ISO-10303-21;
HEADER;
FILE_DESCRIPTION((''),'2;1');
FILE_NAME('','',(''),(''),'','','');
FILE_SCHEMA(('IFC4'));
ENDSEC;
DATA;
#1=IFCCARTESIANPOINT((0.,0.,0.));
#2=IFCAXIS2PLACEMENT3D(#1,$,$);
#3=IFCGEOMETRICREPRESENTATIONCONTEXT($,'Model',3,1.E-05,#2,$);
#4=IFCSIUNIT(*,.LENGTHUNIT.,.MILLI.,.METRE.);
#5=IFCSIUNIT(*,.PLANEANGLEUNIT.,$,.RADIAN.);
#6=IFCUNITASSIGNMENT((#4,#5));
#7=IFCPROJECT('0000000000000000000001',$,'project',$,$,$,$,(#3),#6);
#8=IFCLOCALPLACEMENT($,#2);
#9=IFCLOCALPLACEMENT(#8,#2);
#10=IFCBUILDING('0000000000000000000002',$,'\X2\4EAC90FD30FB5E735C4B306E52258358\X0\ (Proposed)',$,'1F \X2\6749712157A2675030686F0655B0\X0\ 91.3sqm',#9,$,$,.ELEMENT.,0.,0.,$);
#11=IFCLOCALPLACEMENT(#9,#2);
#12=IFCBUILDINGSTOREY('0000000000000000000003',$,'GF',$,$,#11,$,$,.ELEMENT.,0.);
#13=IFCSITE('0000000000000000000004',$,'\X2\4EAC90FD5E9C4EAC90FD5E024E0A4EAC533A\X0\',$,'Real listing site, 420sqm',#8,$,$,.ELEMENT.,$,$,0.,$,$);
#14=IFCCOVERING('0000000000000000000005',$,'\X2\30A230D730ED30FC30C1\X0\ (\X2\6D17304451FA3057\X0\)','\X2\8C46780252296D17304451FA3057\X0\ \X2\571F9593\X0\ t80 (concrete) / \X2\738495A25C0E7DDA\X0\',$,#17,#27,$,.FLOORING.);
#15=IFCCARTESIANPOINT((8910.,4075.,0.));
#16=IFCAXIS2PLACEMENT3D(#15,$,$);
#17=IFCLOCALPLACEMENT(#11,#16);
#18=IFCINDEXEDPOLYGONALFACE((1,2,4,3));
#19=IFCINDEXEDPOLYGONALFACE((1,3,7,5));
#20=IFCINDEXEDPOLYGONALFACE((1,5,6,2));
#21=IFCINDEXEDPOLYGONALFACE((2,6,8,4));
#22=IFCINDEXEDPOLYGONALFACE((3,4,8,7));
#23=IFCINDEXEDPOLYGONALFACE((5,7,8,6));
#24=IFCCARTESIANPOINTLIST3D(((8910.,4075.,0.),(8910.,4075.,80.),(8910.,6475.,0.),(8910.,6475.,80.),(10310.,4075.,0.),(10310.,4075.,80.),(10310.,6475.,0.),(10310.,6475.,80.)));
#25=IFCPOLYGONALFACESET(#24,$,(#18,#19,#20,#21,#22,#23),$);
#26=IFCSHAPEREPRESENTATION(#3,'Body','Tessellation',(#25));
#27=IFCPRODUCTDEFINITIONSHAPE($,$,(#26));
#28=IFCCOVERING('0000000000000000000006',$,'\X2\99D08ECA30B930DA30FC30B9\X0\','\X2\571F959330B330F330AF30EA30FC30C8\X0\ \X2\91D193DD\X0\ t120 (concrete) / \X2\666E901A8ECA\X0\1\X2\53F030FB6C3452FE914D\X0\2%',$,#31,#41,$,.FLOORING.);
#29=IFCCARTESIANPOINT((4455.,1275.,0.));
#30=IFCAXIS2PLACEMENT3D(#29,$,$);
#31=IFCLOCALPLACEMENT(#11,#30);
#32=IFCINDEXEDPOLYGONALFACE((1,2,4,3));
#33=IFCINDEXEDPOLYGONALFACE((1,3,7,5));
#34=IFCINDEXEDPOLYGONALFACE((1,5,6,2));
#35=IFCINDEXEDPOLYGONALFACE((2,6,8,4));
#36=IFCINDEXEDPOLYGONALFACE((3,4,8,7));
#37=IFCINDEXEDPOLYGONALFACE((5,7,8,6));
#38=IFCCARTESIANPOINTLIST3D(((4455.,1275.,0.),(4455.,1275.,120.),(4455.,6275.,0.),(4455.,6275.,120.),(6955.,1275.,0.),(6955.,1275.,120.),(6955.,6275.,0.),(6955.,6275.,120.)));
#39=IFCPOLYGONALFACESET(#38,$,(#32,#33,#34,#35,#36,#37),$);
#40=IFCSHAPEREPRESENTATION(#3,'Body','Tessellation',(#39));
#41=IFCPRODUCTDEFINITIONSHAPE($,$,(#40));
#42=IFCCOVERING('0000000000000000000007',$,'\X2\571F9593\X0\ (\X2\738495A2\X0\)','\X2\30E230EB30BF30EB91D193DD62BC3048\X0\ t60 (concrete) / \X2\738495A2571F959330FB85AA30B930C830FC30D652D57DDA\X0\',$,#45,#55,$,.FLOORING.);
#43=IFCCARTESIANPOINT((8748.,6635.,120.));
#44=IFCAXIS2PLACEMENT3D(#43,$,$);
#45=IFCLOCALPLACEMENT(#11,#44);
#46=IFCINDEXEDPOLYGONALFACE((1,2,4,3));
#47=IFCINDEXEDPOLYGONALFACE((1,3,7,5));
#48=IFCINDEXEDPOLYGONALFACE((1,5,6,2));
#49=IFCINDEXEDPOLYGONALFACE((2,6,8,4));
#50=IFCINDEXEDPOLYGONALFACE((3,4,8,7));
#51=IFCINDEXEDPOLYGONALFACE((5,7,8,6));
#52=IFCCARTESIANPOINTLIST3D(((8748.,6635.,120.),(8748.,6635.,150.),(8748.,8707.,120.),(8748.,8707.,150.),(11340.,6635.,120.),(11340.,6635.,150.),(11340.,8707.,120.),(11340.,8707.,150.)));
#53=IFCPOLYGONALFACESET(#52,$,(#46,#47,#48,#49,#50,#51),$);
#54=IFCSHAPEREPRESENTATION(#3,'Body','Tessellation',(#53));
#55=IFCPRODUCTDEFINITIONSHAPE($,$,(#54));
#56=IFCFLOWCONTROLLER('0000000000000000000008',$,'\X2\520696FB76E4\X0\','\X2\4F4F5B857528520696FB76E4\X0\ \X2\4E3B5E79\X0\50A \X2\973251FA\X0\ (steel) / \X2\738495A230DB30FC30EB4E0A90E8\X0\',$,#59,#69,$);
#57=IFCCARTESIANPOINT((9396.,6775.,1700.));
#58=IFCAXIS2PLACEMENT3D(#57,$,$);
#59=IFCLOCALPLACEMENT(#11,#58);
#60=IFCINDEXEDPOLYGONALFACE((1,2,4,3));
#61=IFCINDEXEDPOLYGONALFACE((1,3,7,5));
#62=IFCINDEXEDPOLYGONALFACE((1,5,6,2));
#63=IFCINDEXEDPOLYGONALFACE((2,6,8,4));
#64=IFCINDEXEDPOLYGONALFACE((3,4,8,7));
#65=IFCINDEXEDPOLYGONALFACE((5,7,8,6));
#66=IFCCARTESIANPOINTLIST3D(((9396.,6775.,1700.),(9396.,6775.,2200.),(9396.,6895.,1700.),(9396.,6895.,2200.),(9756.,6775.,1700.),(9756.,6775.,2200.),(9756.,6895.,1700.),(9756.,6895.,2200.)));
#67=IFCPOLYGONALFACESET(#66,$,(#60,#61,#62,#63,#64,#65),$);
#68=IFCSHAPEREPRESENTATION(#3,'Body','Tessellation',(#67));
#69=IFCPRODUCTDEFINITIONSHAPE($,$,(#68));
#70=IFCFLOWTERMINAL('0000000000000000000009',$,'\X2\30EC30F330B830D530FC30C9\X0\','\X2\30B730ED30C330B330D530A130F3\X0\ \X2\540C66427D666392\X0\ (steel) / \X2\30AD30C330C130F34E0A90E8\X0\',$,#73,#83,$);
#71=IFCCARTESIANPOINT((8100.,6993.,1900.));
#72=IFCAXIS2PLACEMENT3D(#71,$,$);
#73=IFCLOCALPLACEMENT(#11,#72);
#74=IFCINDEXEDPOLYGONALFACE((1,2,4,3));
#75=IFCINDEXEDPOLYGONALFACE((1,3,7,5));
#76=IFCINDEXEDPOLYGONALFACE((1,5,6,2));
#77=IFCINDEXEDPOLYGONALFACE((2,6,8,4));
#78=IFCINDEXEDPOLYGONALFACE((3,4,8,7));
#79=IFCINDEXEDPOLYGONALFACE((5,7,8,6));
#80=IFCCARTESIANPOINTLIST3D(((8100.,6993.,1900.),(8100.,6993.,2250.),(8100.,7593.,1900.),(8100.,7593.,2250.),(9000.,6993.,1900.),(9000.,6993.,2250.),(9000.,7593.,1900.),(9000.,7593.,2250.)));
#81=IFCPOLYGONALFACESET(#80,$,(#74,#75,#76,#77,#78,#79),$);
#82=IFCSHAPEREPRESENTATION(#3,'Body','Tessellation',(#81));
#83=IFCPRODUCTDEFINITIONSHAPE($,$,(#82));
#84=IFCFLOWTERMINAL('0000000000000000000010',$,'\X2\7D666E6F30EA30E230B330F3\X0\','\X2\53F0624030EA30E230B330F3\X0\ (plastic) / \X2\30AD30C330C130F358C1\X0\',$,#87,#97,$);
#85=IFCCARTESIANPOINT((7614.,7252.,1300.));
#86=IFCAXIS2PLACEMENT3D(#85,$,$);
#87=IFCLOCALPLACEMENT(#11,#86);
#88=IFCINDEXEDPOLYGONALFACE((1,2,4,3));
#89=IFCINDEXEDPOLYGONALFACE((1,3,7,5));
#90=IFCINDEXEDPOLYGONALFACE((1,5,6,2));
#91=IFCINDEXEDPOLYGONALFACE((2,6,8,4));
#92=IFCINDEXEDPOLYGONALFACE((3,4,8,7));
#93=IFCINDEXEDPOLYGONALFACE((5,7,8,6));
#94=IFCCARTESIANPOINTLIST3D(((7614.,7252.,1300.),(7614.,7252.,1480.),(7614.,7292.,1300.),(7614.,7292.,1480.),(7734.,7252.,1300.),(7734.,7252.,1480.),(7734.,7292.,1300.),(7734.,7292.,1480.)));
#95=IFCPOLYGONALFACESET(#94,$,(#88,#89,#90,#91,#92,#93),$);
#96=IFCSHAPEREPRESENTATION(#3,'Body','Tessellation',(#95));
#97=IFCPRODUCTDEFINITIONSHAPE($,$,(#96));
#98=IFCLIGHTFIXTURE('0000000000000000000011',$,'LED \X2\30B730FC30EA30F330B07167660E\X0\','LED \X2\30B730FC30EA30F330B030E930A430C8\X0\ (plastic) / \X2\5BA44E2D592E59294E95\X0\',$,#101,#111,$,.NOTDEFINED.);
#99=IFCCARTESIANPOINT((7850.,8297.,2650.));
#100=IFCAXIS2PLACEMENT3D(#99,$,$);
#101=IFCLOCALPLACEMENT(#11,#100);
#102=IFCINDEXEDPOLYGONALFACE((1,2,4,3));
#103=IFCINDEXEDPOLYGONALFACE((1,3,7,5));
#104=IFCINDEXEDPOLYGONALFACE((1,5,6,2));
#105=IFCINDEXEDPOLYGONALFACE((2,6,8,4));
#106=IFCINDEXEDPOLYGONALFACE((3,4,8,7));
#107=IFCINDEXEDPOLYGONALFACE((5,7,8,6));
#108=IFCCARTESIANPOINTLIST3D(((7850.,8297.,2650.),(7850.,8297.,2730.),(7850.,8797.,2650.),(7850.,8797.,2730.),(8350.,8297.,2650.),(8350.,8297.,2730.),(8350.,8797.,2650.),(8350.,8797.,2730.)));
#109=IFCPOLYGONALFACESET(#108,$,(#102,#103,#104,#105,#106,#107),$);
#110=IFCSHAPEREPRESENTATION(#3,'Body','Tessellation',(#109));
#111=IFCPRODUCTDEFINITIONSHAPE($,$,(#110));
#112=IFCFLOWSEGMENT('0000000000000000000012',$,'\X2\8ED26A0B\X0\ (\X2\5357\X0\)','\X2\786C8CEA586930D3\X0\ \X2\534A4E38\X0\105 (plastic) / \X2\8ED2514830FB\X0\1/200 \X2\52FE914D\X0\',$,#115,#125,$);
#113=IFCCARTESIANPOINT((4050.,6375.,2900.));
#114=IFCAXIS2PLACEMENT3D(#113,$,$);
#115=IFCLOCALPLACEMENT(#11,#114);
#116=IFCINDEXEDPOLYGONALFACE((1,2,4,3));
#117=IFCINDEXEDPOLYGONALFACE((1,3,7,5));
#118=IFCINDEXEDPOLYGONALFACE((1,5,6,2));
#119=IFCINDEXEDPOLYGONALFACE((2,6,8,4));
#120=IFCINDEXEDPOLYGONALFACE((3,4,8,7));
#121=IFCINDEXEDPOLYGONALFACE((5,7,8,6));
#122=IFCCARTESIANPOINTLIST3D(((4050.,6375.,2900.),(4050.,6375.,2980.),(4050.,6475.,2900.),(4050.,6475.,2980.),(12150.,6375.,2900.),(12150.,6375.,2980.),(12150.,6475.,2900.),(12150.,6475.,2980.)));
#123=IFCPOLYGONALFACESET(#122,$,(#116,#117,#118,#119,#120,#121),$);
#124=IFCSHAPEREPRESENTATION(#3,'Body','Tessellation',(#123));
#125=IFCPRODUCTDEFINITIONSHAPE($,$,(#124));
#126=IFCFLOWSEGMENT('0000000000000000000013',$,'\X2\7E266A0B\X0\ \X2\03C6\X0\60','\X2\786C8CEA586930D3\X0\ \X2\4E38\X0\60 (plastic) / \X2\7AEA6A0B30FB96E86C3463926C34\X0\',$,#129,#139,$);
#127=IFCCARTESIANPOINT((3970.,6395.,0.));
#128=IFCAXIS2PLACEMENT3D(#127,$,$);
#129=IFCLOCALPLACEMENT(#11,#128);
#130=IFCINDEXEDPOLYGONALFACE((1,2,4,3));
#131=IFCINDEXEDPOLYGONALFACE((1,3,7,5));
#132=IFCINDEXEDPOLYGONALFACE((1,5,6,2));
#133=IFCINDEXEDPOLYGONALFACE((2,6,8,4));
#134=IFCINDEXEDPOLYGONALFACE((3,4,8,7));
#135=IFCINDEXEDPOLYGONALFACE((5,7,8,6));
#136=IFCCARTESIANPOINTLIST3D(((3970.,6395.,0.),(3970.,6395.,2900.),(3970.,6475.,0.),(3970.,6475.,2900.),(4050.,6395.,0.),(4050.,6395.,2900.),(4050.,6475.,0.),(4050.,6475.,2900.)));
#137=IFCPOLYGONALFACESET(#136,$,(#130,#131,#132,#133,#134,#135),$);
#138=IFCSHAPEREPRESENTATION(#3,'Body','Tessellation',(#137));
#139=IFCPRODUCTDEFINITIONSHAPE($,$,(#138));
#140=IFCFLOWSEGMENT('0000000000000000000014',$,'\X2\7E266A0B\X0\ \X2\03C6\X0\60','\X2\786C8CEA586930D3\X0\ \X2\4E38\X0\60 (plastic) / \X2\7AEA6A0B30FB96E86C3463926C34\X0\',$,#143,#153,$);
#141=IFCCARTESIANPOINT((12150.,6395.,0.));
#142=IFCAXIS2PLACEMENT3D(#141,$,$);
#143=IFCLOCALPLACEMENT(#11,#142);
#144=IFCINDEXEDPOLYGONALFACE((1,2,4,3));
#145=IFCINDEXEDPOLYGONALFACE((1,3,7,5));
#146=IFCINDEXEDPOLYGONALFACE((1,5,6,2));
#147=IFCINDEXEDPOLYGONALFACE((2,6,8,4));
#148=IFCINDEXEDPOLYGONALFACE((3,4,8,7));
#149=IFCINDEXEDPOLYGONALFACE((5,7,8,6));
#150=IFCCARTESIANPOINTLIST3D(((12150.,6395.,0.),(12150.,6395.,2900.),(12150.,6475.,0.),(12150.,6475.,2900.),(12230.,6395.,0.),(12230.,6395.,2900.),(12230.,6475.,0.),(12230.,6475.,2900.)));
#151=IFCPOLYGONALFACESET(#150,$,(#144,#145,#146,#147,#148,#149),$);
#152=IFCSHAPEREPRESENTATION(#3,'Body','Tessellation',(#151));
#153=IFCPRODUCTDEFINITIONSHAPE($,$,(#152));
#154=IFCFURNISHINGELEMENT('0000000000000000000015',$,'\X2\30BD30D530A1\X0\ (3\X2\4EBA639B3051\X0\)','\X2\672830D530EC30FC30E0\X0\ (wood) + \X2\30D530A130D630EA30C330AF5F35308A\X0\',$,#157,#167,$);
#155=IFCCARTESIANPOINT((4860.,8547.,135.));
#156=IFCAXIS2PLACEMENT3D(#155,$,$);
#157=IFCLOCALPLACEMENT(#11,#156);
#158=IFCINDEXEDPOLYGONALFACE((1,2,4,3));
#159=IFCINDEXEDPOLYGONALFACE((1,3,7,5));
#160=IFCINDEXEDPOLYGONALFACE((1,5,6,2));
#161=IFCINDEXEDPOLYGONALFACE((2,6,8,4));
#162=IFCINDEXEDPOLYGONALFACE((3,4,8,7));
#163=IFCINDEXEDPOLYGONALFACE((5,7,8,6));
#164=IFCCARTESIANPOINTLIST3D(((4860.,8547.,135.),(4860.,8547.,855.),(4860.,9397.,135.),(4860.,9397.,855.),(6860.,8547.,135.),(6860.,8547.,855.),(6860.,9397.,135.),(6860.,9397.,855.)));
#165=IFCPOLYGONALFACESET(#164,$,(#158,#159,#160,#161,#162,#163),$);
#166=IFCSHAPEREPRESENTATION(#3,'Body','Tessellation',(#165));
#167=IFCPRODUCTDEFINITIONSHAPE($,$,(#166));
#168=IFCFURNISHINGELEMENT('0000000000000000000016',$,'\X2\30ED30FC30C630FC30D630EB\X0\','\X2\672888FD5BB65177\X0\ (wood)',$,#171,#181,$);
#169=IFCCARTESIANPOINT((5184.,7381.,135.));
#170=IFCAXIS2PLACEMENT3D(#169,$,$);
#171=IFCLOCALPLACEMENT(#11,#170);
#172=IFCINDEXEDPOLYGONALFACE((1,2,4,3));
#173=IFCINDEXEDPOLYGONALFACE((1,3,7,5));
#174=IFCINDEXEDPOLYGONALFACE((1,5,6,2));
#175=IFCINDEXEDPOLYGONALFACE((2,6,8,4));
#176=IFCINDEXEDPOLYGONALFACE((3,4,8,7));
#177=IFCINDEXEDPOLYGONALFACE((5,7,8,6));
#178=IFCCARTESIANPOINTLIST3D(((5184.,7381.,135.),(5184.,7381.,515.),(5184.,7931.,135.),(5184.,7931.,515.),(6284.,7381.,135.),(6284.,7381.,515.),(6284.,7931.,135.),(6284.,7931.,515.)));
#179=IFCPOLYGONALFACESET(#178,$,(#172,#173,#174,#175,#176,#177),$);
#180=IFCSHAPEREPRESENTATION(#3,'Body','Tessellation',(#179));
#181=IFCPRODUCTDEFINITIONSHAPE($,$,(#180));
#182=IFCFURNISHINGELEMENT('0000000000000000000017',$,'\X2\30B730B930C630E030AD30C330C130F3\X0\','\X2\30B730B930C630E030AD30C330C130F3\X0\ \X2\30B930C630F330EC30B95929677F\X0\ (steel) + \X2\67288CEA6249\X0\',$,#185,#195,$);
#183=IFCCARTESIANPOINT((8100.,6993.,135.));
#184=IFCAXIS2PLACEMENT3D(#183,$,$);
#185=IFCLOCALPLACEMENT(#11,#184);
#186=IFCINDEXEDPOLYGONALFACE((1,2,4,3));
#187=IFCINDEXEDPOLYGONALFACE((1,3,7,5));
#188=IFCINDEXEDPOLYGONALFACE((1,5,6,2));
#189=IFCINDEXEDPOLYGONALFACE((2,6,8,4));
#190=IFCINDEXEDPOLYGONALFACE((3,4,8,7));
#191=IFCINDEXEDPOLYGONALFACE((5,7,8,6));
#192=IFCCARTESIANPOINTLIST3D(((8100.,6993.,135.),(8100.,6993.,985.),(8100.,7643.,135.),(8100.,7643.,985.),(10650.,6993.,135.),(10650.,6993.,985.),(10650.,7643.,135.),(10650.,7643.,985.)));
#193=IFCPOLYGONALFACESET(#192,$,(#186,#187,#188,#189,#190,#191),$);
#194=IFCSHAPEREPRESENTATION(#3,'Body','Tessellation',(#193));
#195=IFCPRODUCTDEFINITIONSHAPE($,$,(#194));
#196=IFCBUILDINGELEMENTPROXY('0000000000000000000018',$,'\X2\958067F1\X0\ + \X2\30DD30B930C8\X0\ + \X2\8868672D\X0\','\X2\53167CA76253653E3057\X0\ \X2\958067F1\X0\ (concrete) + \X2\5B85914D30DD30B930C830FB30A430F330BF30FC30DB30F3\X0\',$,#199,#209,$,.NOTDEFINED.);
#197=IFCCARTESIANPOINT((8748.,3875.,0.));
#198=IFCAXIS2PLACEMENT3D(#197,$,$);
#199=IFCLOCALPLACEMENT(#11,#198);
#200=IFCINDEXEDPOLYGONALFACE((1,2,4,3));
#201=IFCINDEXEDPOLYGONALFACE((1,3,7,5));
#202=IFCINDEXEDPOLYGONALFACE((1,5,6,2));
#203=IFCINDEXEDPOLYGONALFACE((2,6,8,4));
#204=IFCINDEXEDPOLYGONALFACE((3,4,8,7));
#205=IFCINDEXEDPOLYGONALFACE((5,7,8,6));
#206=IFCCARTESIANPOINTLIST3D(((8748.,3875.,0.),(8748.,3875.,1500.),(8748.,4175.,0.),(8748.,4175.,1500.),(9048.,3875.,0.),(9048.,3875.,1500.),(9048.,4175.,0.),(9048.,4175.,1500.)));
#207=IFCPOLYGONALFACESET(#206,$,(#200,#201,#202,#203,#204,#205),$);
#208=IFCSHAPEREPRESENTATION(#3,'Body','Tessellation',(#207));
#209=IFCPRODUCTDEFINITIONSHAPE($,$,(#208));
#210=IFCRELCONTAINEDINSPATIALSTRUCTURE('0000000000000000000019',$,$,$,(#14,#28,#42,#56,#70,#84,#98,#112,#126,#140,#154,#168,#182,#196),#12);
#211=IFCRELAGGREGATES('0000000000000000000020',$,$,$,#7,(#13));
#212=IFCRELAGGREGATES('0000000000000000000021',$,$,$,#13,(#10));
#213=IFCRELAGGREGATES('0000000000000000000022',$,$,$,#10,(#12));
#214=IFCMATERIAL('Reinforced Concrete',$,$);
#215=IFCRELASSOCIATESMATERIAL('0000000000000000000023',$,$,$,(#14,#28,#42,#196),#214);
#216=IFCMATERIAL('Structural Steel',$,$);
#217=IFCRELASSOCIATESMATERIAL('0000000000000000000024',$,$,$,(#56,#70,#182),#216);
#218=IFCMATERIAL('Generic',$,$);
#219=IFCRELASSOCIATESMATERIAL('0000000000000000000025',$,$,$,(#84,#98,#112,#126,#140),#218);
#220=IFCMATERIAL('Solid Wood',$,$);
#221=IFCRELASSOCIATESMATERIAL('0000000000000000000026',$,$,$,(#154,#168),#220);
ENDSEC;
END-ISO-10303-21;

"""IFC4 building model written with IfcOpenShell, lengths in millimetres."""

from ifc_helpers import new_model, si_unit, frame, frame_2d, origin, place, context, project, spatial, rectangle, extrude, material, element, save


model = new_model("IFC4")

# Units and contexts
model_context = context("Model", 3, precision=1e-05, world=origin())
ifc_project = project(units=[si_unit("LENGTHUNIT", "METRE", prefix="MILLI"), si_unit("PLANEANGLEUNIT", "RADIAN")], contexts=[model_context])

# Site, building, storey
site_placement = place(None, origin())
site = spatial("IfcSite", under=ifc_project, at=site_placement, Name="京都府京都市上京区", ObjectType="Real listing site, 420sqm", CompositionType="ELEMENT", RefElevation=0.0)
building_placement = place(site_placement, origin())
building = spatial("IfcBuilding", under=site, at=building_placement, Name="京都・平屋の別荘 (Proposed)", ObjectType="1F 杉無垢材と漆喰 91.3sqm", CompositionType="ELEMENT", ElevationOfRefHeight=0.0, ElevationOfTerrain=0.0)
storey_placement = place(building_placement, origin())
storey = spatial("IfcBuildingStorey", under=building, at=storey_placement, Name="GF", CompositionType="ELEMENT", Elevation=0.0)

# Shared definitions
ifc_material_1 = material(Name="Solid Wood")

# Shared definitions
ifc_material_2 = material(Name="Reinforced Concrete")

# Shared definitions
ifc_material_3 = material(Name="Structural Steel")

# Coverings
ifc_material_4 = material(Name="Generic")
covering_1_placement = place(storey_placement, frame((8910.0, 4075.0, 0.0)))
element("IfcCovering", 1, at=covering_1_placement, inside=storey, material=ifc_material_2, Name="アプローチ (洗い出し)", Description="豆砂利洗い出し 土間 t80 (concrete) / 玄関導線", PredefinedType="FLOORING", context=model_context, shape_type="SweptSolid", body=[
    extrude(rectangle(XDim=1400.0, YDim=2400.0, at=frame_2d((700.0, 1200.0))), frame((8910.0, 4075.0, 0.0)), (0.0, 0.0, 1.0), 80.0),
])
covering_2_placement = place(storey_placement, frame((4455.0, 1275.0, 0.0)))
element("IfcCovering", 2, at=covering_2_placement, inside=storey, material=ifc_material_2, Name="駐車スペース", Description="土間コンクリート 金鏝 t120 (concrete) / 普通車1台・水勾配2%", PredefinedType="FLOORING", context=model_context, shape_type="SweptSolid", body=[
    extrude(rectangle(XDim=2500.0, YDim=5000.0, at=frame_2d((1250.0, 2500.0))), frame((4455.0, 1275.0, 0.0)), (0.0, 0.0, 1.0), 120.0),
])
covering_3_placement = place(storey_placement, frame((8748.0, 6635.0, 120.0)))
element("IfcCovering", 3, at=covering_3_placement, inside=storey, material=ifc_material_2, Name="土間 (玄関)", Description="モルタル金鏝押え t60 (concrete) / 玄関土間・薪ストーブ動線", PredefinedType="FLOORING", context=model_context, shape_type="SweptSolid", body=[
    extrude(rectangle(XDim=2592.0, YDim=2072.0, at=frame_2d((1296.0, 1036.0))), frame((8748.0, 6635.0, 120.0)), (0.0, 0.0, 1.0), 30.0),
])

# Flow controller
flow_controller_placement = place(storey_placement, frame((9396.0, 6775.0, 1700.0)))
element("IfcFlowController", 4, at=flow_controller_placement, inside=storey, material=ifc_material_3, Name="分電盤", Description="住宅用分電盤 主幹50A 露出 (steel) / 玄関ホール上部", context=model_context, shape_type="SweptSolid", body=[
    extrude(rectangle(XDim=360.0, YDim=120.0, at=frame_2d((180.0, 60.0))), frame((9396.0, 6775.0, 1700.0)), (0.0, 0.0, 1.0), 500.0),
])

# Flow terminals
flow_terminal_1_placement = place(storey_placement, frame((8100.0, 6993.0, 1900.0)))
element("IfcFlowTerminal", 5, at=flow_terminal_1_placement, inside=storey, material=ifc_material_3, Name="レンジフード", Description="シロッコファン 同時給排 (steel) / キッチン上部", context=model_context, shape_type="SweptSolid", body=[
    extrude(rectangle(XDim=900.0, YDim=600.0, at=frame_2d((450.0, 300.0))), frame((8100.0, 6993.0, 1900.0)), (0.0, 0.0, 1.0), 350.0),
])
flow_terminal_2_placement = place(storey_placement, frame((7614.0, 7252.0, 1300.0)))
element("IfcFlowTerminal", 6, at=flow_terminal_2_placement, inside=storey, material=ifc_material_4, Name="給湯リモコン", Description="台所リモコン (plastic) / キッチン壁", context=model_context, shape_type="SweptSolid", body=[
    extrude(rectangle(XDim=120.0, YDim=40.0, at=frame_2d((60.0, 20.0))), frame((7614.0, 7252.0, 1300.0)), (0.0, 0.0, 1.0), 180.0),
])

# Light fixture
light_fixture_placement = place(storey_placement, frame((7850.0, 8297.0, 2650.0)))
element("IfcLightFixture", 7, at=light_fixture_placement, inside=storey, material=ifc_material_4, Name="LED シーリング照明", Description="LED シーリングライト (plastic) / 室中央天井", PredefinedType="NOTDEFINED", context=model_context, shape_type="SweptSolid", body=[
    extrude(rectangle(XDim=500.0, YDim=500.0, at=frame_2d((250.0, 250.0))), frame((7850.0, 8297.0, 2650.0)), (0.0, 0.0, 1.0), 80.0),
])

# Flow segments
flow_segment_1_placement = place(storey_placement, frame((4050.0, 6375.0, 2900.0)))
element("IfcFlowSegment", 8, at=flow_segment_1_placement, inside=storey, material=ifc_material_4, Name="軒樋 (南)", Description="硬質塩ビ 半丸105 (plastic) / 軒先・1/200 勾配", context=model_context, shape_type="SweptSolid", body=[
    extrude(rectangle(XDim=8100.0, YDim=100.0, at=frame_2d((4050.0, 50.0))), frame((4050.0, 6375.0, 2900.0)), (0.0, 0.0, 1.0), 80.0),
])
flow_segment_2_placement = place(storey_placement, frame((3970.0, 6395.0, 0.0)))
element("IfcFlowSegment", 9, at=flow_segment_2_placement, inside=storey, material=ifc_material_4, Name="縦樋 φ60", Description="硬質塩ビ 丸60 (plastic) / 竪樋・雨水排水", context=model_context, shape_type="SweptSolid", body=[
    extrude(rectangle(XDim=80.0, YDim=80.0, at=frame_2d((40.0, 40.0))), frame((3970.0, 6395.0, 0.0)), (0.0, 0.0, 1.0), 2900.0),
])
flow_segment_3_placement = place(storey_placement, frame((12150.0, 6395.0, 0.0)))
element("IfcFlowSegment", 10, at=flow_segment_3_placement, inside=storey, material=ifc_material_4, Name="縦樋 φ60", Description="硬質塩ビ 丸60 (plastic) / 竪樋・雨水排水", context=model_context, shape_type="SweptSolid", body=[
    extrude(rectangle(XDim=80.0, YDim=80.0, at=frame_2d((40.0, 40.0))), frame((12150.0, 6395.0, 0.0)), (0.0, 0.0, 1.0), 2900.0),
])

# Furnishing elements
furnishing_1_placement = place(storey_placement, frame((4860.0, 8547.0, 135.0)))
element("IfcFurnishingElement", 11, at=furnishing_1_placement, inside=storey, material=ifc_material_1, Name="ソファ (3人掛け)", Description="木フレーム (wood) + ファブリック張り", context=model_context, shape_type="SweptSolid", body=[
    extrude(rectangle(XDim=2000.0, YDim=850.0, at=frame_2d((1000.0, 425.0))), frame((4860.0, 8547.0, 135.0)), (0.0, 0.0, 1.0), 720.0),
])
furnishing_2_placement = place(storey_placement, frame((5184.0, 7381.0, 135.0)))
element("IfcFurnishingElement", 12, at=furnishing_2_placement, inside=storey, material=ifc_material_1, Name="ローテーブル", Description="木製家具 (wood)", context=model_context, shape_type="SweptSolid", body=[
    extrude(rectangle(XDim=1100.0, YDim=550.0, at=frame_2d((550.0, 275.0))), frame((5184.0, 7381.0, 135.0)), (0.0, 0.0, 1.0), 380.0),
])
furnishing_3_placement = place(storey_placement, frame((8100.0, 6993.0, 135.0)))
element("IfcFurnishingElement", 13, at=furnishing_3_placement, inside=storey, material=ifc_material_3, Name="システムキッチン", Description="システムキッチン ステンレス天板 (steel) + 木質扉", context=model_context, shape_type="SweptSolid", body=[
    extrude(rectangle(XDim=2550.0, YDim=650.0, at=frame_2d((1275.0, 325.0))), frame((8100.0, 6993.0, 135.0)), (0.0, 0.0, 1.0), 850.0),
])

# Building element proxy
proxy_placement = place(storey_placement, frame((8748.0, 3875.0, 0.0)))
element("IfcBuildingElementProxy", 14, at=proxy_placement, inside=storey, material=ifc_material_2, Name="門柱 + ポスト + 表札", Description="化粧打放し 門柱 (concrete) + 宅配ポスト・インターホン", PredefinedType="NOTDEFINED", context=model_context, shape_type="SweptSolid", body=[
    extrude(rectangle(XDim=300.0, YDim=300.0, at=frame_2d((150.0, 150.0))), frame((8748.0, 3875.0, 0.0)), (0.0, 0.0, 1.0), 1500.0),
])

save(model, "model.ifc")
